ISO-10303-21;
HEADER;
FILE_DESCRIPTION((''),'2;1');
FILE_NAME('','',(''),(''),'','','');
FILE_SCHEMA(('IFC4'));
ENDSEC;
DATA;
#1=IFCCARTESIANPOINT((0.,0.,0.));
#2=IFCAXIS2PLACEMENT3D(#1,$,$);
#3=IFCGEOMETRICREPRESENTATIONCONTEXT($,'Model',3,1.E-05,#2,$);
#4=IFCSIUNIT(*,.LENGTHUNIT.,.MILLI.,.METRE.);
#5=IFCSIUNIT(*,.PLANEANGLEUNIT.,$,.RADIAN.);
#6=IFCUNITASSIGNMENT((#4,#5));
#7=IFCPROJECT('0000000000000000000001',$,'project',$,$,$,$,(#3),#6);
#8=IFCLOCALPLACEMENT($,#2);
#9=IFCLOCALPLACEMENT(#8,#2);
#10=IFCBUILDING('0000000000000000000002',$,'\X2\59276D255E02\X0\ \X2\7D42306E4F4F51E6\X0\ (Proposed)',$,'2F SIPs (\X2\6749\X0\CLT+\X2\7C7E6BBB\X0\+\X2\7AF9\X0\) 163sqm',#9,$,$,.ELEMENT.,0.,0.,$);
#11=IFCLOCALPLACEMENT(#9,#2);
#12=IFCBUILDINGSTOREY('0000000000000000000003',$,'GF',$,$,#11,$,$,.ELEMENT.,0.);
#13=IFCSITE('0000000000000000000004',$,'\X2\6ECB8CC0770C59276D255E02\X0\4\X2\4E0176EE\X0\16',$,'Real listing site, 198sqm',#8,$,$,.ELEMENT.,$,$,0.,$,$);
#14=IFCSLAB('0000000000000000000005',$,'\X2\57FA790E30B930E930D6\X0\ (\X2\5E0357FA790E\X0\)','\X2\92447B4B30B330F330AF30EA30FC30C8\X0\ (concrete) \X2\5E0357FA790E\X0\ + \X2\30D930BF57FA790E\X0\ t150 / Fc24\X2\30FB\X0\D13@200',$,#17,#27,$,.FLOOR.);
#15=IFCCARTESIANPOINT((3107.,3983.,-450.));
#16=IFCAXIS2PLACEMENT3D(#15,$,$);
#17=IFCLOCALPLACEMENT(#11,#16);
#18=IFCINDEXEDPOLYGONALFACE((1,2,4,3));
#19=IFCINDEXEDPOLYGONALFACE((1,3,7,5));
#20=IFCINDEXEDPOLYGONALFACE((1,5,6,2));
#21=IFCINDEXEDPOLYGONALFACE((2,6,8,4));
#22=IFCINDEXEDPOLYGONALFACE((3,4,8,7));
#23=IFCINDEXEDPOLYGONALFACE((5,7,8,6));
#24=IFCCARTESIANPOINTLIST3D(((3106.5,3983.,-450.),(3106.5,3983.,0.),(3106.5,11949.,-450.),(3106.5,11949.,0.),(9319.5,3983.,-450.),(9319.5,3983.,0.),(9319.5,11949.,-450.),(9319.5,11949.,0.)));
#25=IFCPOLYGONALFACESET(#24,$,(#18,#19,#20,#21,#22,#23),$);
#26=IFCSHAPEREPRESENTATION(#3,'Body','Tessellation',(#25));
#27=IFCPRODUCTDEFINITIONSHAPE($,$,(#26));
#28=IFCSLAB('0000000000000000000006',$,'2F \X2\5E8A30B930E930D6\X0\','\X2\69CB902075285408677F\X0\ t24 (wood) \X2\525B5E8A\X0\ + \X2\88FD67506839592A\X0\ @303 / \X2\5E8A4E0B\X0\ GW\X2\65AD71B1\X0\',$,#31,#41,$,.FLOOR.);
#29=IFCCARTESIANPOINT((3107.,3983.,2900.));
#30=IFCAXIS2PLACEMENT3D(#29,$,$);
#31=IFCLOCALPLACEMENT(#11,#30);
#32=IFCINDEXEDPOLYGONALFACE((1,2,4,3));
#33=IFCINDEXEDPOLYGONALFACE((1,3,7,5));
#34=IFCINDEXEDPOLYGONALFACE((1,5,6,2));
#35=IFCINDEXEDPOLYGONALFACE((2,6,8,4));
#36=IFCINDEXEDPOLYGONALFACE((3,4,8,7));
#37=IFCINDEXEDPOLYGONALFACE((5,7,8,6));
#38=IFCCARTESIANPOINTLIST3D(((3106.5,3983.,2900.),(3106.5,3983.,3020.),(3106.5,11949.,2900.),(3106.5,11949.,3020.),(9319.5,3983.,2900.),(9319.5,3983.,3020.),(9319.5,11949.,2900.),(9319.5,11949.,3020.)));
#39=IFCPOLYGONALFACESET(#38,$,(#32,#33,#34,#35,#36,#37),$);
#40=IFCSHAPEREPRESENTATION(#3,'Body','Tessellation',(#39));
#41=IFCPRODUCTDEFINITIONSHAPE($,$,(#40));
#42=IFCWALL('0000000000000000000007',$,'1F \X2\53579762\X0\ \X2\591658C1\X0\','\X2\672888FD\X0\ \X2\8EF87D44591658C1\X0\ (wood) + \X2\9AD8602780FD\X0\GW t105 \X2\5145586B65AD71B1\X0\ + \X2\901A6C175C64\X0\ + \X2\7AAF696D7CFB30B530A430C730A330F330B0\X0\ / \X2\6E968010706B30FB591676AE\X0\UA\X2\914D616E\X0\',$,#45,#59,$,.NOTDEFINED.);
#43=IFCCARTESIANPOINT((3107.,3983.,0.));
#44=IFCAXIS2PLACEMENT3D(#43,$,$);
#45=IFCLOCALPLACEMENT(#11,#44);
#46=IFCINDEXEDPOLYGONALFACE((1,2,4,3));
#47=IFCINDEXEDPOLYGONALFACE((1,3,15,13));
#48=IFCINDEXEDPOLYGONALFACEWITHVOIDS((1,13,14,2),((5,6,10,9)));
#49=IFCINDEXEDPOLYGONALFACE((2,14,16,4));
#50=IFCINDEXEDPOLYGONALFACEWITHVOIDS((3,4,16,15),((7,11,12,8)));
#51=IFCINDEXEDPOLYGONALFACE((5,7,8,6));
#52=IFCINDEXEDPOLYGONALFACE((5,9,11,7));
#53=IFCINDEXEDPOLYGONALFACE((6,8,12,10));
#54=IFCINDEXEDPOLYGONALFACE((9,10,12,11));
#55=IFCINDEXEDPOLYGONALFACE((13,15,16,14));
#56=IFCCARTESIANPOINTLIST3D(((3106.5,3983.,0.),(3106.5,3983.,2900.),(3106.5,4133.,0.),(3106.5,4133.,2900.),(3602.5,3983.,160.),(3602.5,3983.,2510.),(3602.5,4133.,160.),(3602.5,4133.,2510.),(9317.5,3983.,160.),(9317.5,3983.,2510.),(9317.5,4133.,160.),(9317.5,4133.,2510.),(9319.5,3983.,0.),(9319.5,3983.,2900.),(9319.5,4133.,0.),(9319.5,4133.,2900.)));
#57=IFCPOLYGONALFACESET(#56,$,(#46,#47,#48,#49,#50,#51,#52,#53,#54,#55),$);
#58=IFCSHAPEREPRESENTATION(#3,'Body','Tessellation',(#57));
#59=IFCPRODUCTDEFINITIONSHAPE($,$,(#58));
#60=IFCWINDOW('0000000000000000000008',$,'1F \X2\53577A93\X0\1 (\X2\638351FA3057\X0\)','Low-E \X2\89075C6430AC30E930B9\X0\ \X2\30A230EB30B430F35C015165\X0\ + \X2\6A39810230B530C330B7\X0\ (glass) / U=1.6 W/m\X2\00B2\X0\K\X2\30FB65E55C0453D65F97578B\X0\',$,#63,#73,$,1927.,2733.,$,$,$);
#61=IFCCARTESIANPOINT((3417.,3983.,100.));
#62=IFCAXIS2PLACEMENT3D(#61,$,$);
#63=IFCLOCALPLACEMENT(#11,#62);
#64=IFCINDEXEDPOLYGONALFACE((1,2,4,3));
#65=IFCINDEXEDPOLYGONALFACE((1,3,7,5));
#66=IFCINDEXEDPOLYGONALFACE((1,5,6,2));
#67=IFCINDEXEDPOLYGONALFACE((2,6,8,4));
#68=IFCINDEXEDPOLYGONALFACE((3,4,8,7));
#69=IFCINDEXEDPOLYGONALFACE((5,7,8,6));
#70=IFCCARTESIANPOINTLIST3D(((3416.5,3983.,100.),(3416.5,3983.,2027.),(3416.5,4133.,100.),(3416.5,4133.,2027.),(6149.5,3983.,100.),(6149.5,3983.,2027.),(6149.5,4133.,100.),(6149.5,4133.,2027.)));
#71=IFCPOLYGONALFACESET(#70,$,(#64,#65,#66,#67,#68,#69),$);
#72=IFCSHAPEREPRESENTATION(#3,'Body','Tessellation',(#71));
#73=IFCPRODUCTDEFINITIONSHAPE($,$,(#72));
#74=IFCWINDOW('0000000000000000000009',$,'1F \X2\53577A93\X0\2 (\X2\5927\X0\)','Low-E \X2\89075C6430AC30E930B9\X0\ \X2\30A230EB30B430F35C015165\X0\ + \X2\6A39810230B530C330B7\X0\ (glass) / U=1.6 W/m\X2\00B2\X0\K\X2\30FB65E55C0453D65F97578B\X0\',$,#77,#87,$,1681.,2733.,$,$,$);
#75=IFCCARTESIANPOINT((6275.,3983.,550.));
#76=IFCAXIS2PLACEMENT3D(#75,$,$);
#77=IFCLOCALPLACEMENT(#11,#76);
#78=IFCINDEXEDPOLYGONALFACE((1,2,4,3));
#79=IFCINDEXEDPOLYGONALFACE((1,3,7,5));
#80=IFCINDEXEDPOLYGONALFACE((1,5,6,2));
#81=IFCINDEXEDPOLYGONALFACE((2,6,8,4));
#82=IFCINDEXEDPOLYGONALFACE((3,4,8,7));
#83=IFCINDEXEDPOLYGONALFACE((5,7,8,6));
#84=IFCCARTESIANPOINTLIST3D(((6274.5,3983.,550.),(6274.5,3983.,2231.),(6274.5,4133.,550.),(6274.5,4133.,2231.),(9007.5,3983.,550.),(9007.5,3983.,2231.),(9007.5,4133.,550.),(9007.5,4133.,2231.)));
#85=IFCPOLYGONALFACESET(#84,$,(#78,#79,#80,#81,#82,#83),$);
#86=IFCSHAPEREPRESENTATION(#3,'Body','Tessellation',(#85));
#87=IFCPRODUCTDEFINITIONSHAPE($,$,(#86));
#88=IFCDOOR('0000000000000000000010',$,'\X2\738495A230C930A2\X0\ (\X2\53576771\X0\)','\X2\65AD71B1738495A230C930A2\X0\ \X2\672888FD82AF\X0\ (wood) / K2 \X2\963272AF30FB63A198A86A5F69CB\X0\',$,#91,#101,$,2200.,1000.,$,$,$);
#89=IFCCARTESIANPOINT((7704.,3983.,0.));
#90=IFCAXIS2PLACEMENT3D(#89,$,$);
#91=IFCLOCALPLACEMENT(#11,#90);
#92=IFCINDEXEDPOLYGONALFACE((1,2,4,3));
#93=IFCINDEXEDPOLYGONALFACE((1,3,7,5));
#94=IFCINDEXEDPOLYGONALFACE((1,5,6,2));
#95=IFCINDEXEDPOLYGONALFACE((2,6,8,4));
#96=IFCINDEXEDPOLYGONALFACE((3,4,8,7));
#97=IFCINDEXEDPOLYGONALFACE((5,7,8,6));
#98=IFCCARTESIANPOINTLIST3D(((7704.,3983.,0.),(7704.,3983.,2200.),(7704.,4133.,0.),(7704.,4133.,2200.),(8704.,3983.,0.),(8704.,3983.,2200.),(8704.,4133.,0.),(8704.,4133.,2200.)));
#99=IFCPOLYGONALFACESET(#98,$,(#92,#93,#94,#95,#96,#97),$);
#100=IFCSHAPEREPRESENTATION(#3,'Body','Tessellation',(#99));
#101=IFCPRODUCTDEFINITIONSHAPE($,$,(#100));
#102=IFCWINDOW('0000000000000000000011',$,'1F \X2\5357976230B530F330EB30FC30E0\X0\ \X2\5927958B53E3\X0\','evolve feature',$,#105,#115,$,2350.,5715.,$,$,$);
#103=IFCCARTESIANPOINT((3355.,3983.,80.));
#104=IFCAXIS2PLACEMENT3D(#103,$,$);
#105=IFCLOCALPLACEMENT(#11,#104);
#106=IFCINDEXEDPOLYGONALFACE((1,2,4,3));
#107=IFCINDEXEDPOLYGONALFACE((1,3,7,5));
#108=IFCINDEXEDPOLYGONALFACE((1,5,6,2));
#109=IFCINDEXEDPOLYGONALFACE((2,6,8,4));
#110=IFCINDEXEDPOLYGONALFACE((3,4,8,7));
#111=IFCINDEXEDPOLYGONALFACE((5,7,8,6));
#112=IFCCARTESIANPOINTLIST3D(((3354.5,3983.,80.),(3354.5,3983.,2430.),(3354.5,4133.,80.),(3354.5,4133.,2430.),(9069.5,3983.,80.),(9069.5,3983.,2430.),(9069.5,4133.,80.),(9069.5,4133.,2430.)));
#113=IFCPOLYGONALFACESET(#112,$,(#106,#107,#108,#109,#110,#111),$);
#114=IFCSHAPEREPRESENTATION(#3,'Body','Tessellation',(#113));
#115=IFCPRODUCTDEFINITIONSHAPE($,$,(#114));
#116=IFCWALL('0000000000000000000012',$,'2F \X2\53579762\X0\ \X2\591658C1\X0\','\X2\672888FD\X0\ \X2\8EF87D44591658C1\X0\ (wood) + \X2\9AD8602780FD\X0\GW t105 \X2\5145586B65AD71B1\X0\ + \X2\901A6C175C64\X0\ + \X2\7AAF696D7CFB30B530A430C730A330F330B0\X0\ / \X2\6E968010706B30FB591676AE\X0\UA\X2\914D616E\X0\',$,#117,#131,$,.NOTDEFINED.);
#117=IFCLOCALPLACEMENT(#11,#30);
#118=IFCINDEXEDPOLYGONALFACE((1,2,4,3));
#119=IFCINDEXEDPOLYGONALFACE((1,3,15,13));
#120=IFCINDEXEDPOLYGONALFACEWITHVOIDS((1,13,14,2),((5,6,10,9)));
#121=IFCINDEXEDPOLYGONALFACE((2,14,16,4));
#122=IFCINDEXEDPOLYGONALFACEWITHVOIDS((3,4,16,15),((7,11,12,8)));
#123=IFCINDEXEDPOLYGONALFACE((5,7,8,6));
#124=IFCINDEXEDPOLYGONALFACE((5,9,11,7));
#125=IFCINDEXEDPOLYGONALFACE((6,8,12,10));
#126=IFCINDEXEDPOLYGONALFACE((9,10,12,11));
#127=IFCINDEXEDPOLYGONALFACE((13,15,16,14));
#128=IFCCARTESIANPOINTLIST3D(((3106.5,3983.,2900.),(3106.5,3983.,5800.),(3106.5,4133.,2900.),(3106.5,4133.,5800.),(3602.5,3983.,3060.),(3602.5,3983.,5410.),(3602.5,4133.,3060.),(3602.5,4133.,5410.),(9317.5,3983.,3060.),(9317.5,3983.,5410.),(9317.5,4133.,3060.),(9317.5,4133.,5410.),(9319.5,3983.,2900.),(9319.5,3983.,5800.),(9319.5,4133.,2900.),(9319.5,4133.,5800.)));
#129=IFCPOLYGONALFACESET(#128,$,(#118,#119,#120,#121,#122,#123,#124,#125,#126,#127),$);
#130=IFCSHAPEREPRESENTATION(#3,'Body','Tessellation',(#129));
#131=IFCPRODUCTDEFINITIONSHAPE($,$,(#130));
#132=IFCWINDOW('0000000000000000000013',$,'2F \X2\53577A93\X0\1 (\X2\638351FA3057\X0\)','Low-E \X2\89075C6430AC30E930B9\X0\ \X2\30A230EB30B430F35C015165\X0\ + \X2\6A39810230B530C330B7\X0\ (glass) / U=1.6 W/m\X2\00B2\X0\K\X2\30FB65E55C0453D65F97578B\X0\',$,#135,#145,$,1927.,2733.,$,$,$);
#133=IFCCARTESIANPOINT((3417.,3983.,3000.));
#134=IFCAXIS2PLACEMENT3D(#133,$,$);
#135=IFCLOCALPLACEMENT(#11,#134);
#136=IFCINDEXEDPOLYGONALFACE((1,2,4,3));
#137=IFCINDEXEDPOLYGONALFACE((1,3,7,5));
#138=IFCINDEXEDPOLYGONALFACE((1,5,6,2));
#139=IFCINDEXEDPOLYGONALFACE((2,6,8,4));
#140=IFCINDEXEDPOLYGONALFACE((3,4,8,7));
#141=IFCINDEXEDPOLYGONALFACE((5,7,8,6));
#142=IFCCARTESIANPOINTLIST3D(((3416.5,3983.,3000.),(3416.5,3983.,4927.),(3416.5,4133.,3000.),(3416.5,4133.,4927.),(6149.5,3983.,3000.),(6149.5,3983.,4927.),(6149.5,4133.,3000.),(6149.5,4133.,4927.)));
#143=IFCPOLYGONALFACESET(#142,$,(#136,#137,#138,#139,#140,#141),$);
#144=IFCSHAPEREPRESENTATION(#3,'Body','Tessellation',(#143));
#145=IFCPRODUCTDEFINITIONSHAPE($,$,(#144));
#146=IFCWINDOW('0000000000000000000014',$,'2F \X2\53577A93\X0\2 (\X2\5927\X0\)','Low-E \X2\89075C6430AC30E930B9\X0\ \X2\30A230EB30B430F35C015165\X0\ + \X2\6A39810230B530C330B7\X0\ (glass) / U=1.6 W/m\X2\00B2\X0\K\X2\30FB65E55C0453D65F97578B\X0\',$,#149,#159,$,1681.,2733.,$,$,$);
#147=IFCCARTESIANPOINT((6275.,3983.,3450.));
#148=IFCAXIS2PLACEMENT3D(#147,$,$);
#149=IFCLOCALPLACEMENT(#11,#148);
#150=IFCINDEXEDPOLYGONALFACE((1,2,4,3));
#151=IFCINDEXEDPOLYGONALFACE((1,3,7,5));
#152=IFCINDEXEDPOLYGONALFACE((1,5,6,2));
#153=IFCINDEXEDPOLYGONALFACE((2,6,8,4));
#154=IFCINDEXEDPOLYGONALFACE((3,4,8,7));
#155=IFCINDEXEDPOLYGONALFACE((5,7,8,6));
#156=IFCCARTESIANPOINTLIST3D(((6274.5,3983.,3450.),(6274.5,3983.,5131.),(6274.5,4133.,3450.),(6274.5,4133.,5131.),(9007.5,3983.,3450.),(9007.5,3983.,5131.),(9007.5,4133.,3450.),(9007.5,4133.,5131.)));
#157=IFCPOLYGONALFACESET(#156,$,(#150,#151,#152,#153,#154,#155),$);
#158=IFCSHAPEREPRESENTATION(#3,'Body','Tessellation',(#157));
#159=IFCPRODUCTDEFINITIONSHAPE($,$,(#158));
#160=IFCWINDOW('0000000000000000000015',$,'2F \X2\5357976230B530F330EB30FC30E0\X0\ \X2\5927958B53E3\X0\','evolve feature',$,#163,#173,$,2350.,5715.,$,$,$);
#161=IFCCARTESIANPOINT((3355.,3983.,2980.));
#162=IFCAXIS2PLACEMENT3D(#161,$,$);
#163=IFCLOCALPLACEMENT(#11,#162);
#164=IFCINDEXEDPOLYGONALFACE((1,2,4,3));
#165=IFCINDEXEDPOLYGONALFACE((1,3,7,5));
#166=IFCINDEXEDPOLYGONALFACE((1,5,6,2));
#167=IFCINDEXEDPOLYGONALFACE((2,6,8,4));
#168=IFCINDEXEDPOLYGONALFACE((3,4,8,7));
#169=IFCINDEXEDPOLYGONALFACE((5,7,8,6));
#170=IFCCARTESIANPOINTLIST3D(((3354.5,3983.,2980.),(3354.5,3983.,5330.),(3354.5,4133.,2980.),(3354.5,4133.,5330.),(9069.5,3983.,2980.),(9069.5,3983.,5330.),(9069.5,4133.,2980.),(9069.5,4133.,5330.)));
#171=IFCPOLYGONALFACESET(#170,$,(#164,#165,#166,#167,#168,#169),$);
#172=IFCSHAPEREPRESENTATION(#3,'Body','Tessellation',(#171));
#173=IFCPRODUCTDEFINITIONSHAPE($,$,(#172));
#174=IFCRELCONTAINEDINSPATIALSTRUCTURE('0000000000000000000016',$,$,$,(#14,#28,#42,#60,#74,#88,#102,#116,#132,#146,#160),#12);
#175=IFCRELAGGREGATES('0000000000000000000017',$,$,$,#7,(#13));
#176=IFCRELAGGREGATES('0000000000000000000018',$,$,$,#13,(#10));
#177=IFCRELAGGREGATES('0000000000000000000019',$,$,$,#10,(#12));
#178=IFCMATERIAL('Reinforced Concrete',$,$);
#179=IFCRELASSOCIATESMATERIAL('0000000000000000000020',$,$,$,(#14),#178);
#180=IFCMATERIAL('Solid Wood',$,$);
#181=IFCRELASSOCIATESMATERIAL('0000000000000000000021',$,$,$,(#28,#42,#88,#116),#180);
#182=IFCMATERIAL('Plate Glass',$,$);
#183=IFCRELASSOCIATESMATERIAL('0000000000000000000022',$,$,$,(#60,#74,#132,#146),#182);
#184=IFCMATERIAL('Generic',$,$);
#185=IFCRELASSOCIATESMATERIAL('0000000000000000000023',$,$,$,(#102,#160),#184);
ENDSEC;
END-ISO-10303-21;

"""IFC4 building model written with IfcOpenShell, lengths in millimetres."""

from ifc_helpers import new_model, si_unit, frame, frame_2d, origin, place, context, project, spatial, rectangle, extrude, material, element, fill, save


model = new_model("IFC4")

# Units and contexts
model_context = context("Model", 3, precision=1e-05, world=origin())
ifc_project = project(units=[si_unit("LENGTHUNIT", "METRE", prefix="MILLI"), si_unit("PLANEANGLEUNIT", "RADIAN")], contexts=[model_context])

# Site, building, storey
site_placement = place(None, origin())
site = spatial("IfcSite", under=ifc_project, at=site_placement, Name="滋賀県大津市4丁目16", ObjectType="Real listing site, 198sqm", CompositionType="ELEMENT", RefElevation=0.0)
building_placement = place(site_placement, origin())
building = spatial("IfcBuilding", under=site, at=building_placement, Name="大津市 終の住処 (Proposed)", ObjectType="2F SIPs (杉CLT+籾殻+竹) 163sqm", CompositionType="ELEMENT", ElevationOfRefHeight=0.0, ElevationOfTerrain=0.0)
storey_placement = place(building_placement, origin())
storey = spatial("IfcBuildingStorey", under=building, at=storey_placement, Name="GF", CompositionType="ELEMENT", Elevation=0.0)

# Slabs
ifc_material_1 = material(Name="Reinforced Concrete")
slab_1_placement = place(storey_placement, frame((3107.0, 3983.0, -450.0)))
element("IfcSlab", 1, at=slab_1_placement, inside=storey, material=ifc_material_1, Name="基礎スラブ (布基礎)", Description="鉄筋コンクリート (concrete) 布基礎 + ベタ基礎 t150 / Fc24・D13@200", PredefinedType="FLOOR", context=model_context, shape_type="SweptSolid", body=[
    extrude(rectangle(XDim=6213.0, YDim=7966.0, at=frame_2d((3106.0, 3983.0))), frame((3107.0, 3983.0, -450.0)), (0.0, 0.0, 1.0), 450.0),
])
ifc_material_2 = material(Name="Solid Wood")
slab_2_placement = place(storey_placement, frame((3107.0, 3983.0, 2900.0)))
element("IfcSlab", 2, at=slab_2_placement, inside=storey, material=ifc_material_2, Name="2F 床スラブ", Description="構造用合板 t24 (wood) 剛床 + 製材根太 @303 / 床下 GW断熱", PredefinedType="FLOOR", context=model_context, shape_type="SweptSolid", body=[
    extrude(rectangle(XDim=6213.0, YDim=7966.0, at=frame_2d((3106.0, 3983.0))), frame((3107.0, 3983.0, 2900.0)), (0.0, 0.0, 1.0), 120.0),
])
ifc_material_3 = material(Name="Generic")

# Wall, openings, windows, door
wall_1_placement = place(storey_placement, frame((3107.0, 3983.0, 0.0)))
wall_1 = element("IfcWall", 3, at=wall_1_placement, inside=storey, material=ifc_material_2, Name="1F 南面 外壁", Description="木製 軸組外壁 (wood) + 高性能GW t105 充填断熱 + 通気層 + 窯業系サイディング / 準耐火・外皮UA配慮", PredefinedType="NOTDEFINED", context=model_context, shape_type="SweptSolid", body=[
    extrude(rectangle(XDim=6213.0, YDim=150.0, at=frame_2d((3106.0, 75.0))), frame((3107.0, 3983.0, 0.0)), (0.0, 0.0, 1.0), 2900.0),
])
opening_1_placement = place(storey_placement, frame((3417.0, 3983.0, 100.0)))
opening_1 = element("IfcOpeningElement", 4, at=opening_1_placement, cuts=wall_1, PredefinedType="NOTDEFINED", context=model_context, shape_type="SweptSolid", body=[
    extrude(rectangle(XDim=2733.0, YDim=150.0, at=frame_2d((1366.0, 75.0))), frame((3417.0, 3983.0, 100.0)), (0.0, 0.0, 1.0), 1927.0),
])
opening_2_placement = place(storey_placement, frame((6275.0, 3983.0, 550.0)))
opening_2 = element("IfcOpeningElement", 5, at=opening_2_placement, cuts=wall_1, PredefinedType="NOTDEFINED", context=model_context, shape_type="SweptSolid", body=[
    extrude(rectangle(XDim=2733.0, YDim=150.0, at=frame_2d((1366.0, 75.0))), frame((6275.0, 3983.0, 550.0)), (0.0, 0.0, 1.0), 1681.0),
])
opening_3_placement = place(storey_placement, frame((7704.0, 3983.0, 0.0)))
opening_3 = element("IfcOpeningElement", 6, at=opening_3_placement, cuts=wall_1, PredefinedType="NOTDEFINED", context=model_context, shape_type="SweptSolid", body=[
    extrude(rectangle(XDim=1000.0, YDim=150.0, at=frame_2d((500.0, 75.0))), frame((7704.0, 3983.0, 0.0)), (0.0, 0.0, 1.0), 2200.0),
])
opening_4_placement = place(storey_placement, frame((3355.0, 3983.0, 80.0)))
opening_4 = element("IfcOpeningElement", 7, at=opening_4_placement, cuts=wall_1, PredefinedType="NOTDEFINED", context=model_context, shape_type="SweptSolid", body=[
    extrude(rectangle(XDim=5715.0, YDim=150.0, at=frame_2d((2857.0, 75.0))), frame((3355.0, 3983.0, 80.0)), (0.0, 0.0, 1.0), 2350.0),
])
ifc_material_4 = material(Name="Plate Glass")
window_1_placement = place(storey_placement, frame((3417.0, 3983.0, 100.0)))
window_1 = element("IfcWindow", 8, at=window_1_placement, inside=storey, material=ifc_material_4, Name="1F 南窓1 (掃出し)", Description="Low-E 複層ガラス アルゴン封入 + 樹脂サッシ (glass) / U=1.6 W/m²K・日射取得型", OverallHeight=1927.0, OverallWidth=2733.0, context=model_context, shape_type="SweptSolid", body=[
    extrude(rectangle(XDim=2733.0, YDim=150.0, at=frame_2d((1366.0, 75.0))), frame((3417.0, 3983.0, 100.0)), (0.0, 0.0, 1.0), 1927.0),
])
fill(opening_1, window_1)
window_2_placement = place(storey_placement, frame((6275.0, 3983.0, 550.0)))
window_2 = element("IfcWindow", 9, at=window_2_placement, inside=storey, material=ifc_material_4, Name="1F 南窓2 (大)", Description="Low-E 複層ガラス アルゴン封入 + 樹脂サッシ (glass) / U=1.6 W/m²K・日射取得型", OverallHeight=1681.0, OverallWidth=2733.0, context=model_context, shape_type="SweptSolid", body=[
    extrude(rectangle(XDim=2733.0, YDim=150.0, at=frame_2d((1366.0, 75.0))), frame((6275.0, 3983.0, 550.0)), (0.0, 0.0, 1.0), 1681.0),
])
fill(opening_2, window_2)
door_placement = place(storey_placement, frame((7704.0, 3983.0, 0.0)))
door = element("IfcDoor", 10, at=door_placement, inside=storey, material=ifc_material_2, Name="玄関ドア (南東)", Description="断熱玄関ドア 木製芯 (wood) / K2 防犯・採風機構", OverallHeight=2200.0, OverallWidth=1000.0, context=model_context, shape_type="SweptSolid", body=[
    extrude(rectangle(XDim=1000.0, YDim=150.0, at=frame_2d((500.0, 75.0))), frame((7704.0, 3983.0, 0.0)), (0.0, 0.0, 1.0), 2200.0),
])
fill(opening_3, door)
window_3_placement = place(storey_placement, frame((3355.0, 3983.0, 80.0)))
window_3 = element("IfcWindow", 11, at=window_3_placement, inside=storey, material=ifc_material_3, Name="1F 南面サンルーム 大開口", Description="evolve feature", OverallHeight=2350.0, OverallWidth=5715.0, context=model_context, shape_type="SweptSolid", body=[
    extrude(rectangle(XDim=5715.0, YDim=150.0, at=frame_2d((2857.0, 75.0))), frame((3355.0, 3983.0, 80.0)), (0.0, 0.0, 1.0), 2350.0),
])
fill(opening_4, window_3)

# Wall, openings, windows
wall_2_placement = place(storey_placement, frame((3107.0, 3983.0, 2900.0)))
wall_2 = element("IfcWall", 12, at=wall_2_placement, inside=storey, material=ifc_material_2, Name="2F 南面 外壁", Description="木製 軸組外壁 (wood) + 高性能GW t105 充填断熱 + 通気層 + 窯業系サイディング / 準耐火・外皮UA配慮", PredefinedType="NOTDEFINED", context=model_context, shape_type="SweptSolid", body=[
    extrude(rectangle(XDim=6213.0, YDim=150.0, at=frame_2d((3106.0, 75.0))), frame((3107.0, 3983.0, 2900.0)), (0.0, 0.0, 1.0), 2900.0),
])
opening_5_placement = place(storey_placement, frame((3417.0, 3983.0, 3000.0)))
opening_5 = element("IfcOpeningElement", 13, at=opening_5_placement, cuts=wall_2, PredefinedType="NOTDEFINED", context=model_context, shape_type="SweptSolid", body=[
    extrude(rectangle(XDim=2733.0, YDim=150.0, at=frame_2d((1366.0, 75.0))), frame((3417.0, 3983.0, 3000.0)), (0.0, 0.0, 1.0), 1927.0),
])
opening_6_placement = place(storey_placement, frame((6275.0, 3983.0, 3450.0)))
opening_6 = element("IfcOpeningElement", 14, at=opening_6_placement, cuts=wall_2, PredefinedType="NOTDEFINED", context=model_context, shape_type="SweptSolid", body=[
    extrude(rectangle(XDim=2733.0, YDim=150.0, at=frame_2d((1366.0, 75.0))), frame((6275.0, 3983.0, 3450.0)), (0.0, 0.0, 1.0), 1681.0),
])
opening_7_placement = place(storey_placement, frame((3355.0, 3983.0, 2980.0)))
opening_7 = element("IfcOpeningElement", 15, at=opening_7_placement, cuts=wall_2, PredefinedType="NOTDEFINED", context=model_context, shape_type="SweptSolid", body=[
    extrude(rectangle(XDim=5715.0, YDim=150.0, at=frame_2d((2857.0, 75.0))), frame((3355.0, 3983.0, 2980.0)), (0.0, 0.0, 1.0), 2350.0),
])
window_4_placement = place(storey_placement, frame((3417.0, 3983.0, 3000.0)))
window_4 = element("IfcWindow", 16, at=window_4_placement, inside=storey, material=ifc_material_4, Name="2F 南窓1 (掃出し)", Description="Low-E 複層ガラス アルゴン封入 + 樹脂サッシ (glass) / U=1.6 W/m²K・日射取得型", OverallHeight=1927.0, OverallWidth=2733.0, context=model_context, shape_type="SweptSolid", body=[
    extrude(rectangle(XDim=2733.0, YDim=150.0, at=frame_2d((1366.0, 75.0))), frame((3417.0, 3983.0, 3000.0)), (0.0, 0.0, 1.0), 1927.0),
])
fill(opening_5, window_4)
window_5_placement = place(storey_placement, frame((6275.0, 3983.0, 3450.0)))
window_5 = element("IfcWindow", 17, at=window_5_placement, inside=storey, material=ifc_material_4, Name="2F 南窓2 (大)", Description="Low-E 複層ガラス アルゴン封入 + 樹脂サッシ (glass) / U=1.6 W/m²K・日射取得型", OverallHeight=1681.0, OverallWidth=2733.0, context=model_context, shape_type="SweptSolid", body=[
    extrude(rectangle(XDim=2733.0, YDim=150.0, at=frame_2d((1366.0, 75.0))), frame((6275.0, 3983.0, 3450.0)), (0.0, 0.0, 1.0), 1681.0),
])
fill(opening_6, window_5)
window_6_placement = place(storey_placement, frame((3355.0, 3983.0, 2980.0)))
window_6 = element("IfcWindow", 18, at=window_6_placement, inside=storey, material=ifc_material_3, Name="2F 南面サンルーム 大開口", Description="evolve feature", OverallHeight=2350.0, OverallWidth=5715.0, context=model_context, shape_type="SweptSolid", body=[
    extrude(rectangle(XDim=5715.0, YDim=150.0, at=frame_2d((2857.0, 75.0))), frame((3355.0, 3983.0, 2980.0)), (0.0, 0.0, 1.0), 2350.0),
])
fill(opening_7, window_6)

save(model, "model.ifc")
